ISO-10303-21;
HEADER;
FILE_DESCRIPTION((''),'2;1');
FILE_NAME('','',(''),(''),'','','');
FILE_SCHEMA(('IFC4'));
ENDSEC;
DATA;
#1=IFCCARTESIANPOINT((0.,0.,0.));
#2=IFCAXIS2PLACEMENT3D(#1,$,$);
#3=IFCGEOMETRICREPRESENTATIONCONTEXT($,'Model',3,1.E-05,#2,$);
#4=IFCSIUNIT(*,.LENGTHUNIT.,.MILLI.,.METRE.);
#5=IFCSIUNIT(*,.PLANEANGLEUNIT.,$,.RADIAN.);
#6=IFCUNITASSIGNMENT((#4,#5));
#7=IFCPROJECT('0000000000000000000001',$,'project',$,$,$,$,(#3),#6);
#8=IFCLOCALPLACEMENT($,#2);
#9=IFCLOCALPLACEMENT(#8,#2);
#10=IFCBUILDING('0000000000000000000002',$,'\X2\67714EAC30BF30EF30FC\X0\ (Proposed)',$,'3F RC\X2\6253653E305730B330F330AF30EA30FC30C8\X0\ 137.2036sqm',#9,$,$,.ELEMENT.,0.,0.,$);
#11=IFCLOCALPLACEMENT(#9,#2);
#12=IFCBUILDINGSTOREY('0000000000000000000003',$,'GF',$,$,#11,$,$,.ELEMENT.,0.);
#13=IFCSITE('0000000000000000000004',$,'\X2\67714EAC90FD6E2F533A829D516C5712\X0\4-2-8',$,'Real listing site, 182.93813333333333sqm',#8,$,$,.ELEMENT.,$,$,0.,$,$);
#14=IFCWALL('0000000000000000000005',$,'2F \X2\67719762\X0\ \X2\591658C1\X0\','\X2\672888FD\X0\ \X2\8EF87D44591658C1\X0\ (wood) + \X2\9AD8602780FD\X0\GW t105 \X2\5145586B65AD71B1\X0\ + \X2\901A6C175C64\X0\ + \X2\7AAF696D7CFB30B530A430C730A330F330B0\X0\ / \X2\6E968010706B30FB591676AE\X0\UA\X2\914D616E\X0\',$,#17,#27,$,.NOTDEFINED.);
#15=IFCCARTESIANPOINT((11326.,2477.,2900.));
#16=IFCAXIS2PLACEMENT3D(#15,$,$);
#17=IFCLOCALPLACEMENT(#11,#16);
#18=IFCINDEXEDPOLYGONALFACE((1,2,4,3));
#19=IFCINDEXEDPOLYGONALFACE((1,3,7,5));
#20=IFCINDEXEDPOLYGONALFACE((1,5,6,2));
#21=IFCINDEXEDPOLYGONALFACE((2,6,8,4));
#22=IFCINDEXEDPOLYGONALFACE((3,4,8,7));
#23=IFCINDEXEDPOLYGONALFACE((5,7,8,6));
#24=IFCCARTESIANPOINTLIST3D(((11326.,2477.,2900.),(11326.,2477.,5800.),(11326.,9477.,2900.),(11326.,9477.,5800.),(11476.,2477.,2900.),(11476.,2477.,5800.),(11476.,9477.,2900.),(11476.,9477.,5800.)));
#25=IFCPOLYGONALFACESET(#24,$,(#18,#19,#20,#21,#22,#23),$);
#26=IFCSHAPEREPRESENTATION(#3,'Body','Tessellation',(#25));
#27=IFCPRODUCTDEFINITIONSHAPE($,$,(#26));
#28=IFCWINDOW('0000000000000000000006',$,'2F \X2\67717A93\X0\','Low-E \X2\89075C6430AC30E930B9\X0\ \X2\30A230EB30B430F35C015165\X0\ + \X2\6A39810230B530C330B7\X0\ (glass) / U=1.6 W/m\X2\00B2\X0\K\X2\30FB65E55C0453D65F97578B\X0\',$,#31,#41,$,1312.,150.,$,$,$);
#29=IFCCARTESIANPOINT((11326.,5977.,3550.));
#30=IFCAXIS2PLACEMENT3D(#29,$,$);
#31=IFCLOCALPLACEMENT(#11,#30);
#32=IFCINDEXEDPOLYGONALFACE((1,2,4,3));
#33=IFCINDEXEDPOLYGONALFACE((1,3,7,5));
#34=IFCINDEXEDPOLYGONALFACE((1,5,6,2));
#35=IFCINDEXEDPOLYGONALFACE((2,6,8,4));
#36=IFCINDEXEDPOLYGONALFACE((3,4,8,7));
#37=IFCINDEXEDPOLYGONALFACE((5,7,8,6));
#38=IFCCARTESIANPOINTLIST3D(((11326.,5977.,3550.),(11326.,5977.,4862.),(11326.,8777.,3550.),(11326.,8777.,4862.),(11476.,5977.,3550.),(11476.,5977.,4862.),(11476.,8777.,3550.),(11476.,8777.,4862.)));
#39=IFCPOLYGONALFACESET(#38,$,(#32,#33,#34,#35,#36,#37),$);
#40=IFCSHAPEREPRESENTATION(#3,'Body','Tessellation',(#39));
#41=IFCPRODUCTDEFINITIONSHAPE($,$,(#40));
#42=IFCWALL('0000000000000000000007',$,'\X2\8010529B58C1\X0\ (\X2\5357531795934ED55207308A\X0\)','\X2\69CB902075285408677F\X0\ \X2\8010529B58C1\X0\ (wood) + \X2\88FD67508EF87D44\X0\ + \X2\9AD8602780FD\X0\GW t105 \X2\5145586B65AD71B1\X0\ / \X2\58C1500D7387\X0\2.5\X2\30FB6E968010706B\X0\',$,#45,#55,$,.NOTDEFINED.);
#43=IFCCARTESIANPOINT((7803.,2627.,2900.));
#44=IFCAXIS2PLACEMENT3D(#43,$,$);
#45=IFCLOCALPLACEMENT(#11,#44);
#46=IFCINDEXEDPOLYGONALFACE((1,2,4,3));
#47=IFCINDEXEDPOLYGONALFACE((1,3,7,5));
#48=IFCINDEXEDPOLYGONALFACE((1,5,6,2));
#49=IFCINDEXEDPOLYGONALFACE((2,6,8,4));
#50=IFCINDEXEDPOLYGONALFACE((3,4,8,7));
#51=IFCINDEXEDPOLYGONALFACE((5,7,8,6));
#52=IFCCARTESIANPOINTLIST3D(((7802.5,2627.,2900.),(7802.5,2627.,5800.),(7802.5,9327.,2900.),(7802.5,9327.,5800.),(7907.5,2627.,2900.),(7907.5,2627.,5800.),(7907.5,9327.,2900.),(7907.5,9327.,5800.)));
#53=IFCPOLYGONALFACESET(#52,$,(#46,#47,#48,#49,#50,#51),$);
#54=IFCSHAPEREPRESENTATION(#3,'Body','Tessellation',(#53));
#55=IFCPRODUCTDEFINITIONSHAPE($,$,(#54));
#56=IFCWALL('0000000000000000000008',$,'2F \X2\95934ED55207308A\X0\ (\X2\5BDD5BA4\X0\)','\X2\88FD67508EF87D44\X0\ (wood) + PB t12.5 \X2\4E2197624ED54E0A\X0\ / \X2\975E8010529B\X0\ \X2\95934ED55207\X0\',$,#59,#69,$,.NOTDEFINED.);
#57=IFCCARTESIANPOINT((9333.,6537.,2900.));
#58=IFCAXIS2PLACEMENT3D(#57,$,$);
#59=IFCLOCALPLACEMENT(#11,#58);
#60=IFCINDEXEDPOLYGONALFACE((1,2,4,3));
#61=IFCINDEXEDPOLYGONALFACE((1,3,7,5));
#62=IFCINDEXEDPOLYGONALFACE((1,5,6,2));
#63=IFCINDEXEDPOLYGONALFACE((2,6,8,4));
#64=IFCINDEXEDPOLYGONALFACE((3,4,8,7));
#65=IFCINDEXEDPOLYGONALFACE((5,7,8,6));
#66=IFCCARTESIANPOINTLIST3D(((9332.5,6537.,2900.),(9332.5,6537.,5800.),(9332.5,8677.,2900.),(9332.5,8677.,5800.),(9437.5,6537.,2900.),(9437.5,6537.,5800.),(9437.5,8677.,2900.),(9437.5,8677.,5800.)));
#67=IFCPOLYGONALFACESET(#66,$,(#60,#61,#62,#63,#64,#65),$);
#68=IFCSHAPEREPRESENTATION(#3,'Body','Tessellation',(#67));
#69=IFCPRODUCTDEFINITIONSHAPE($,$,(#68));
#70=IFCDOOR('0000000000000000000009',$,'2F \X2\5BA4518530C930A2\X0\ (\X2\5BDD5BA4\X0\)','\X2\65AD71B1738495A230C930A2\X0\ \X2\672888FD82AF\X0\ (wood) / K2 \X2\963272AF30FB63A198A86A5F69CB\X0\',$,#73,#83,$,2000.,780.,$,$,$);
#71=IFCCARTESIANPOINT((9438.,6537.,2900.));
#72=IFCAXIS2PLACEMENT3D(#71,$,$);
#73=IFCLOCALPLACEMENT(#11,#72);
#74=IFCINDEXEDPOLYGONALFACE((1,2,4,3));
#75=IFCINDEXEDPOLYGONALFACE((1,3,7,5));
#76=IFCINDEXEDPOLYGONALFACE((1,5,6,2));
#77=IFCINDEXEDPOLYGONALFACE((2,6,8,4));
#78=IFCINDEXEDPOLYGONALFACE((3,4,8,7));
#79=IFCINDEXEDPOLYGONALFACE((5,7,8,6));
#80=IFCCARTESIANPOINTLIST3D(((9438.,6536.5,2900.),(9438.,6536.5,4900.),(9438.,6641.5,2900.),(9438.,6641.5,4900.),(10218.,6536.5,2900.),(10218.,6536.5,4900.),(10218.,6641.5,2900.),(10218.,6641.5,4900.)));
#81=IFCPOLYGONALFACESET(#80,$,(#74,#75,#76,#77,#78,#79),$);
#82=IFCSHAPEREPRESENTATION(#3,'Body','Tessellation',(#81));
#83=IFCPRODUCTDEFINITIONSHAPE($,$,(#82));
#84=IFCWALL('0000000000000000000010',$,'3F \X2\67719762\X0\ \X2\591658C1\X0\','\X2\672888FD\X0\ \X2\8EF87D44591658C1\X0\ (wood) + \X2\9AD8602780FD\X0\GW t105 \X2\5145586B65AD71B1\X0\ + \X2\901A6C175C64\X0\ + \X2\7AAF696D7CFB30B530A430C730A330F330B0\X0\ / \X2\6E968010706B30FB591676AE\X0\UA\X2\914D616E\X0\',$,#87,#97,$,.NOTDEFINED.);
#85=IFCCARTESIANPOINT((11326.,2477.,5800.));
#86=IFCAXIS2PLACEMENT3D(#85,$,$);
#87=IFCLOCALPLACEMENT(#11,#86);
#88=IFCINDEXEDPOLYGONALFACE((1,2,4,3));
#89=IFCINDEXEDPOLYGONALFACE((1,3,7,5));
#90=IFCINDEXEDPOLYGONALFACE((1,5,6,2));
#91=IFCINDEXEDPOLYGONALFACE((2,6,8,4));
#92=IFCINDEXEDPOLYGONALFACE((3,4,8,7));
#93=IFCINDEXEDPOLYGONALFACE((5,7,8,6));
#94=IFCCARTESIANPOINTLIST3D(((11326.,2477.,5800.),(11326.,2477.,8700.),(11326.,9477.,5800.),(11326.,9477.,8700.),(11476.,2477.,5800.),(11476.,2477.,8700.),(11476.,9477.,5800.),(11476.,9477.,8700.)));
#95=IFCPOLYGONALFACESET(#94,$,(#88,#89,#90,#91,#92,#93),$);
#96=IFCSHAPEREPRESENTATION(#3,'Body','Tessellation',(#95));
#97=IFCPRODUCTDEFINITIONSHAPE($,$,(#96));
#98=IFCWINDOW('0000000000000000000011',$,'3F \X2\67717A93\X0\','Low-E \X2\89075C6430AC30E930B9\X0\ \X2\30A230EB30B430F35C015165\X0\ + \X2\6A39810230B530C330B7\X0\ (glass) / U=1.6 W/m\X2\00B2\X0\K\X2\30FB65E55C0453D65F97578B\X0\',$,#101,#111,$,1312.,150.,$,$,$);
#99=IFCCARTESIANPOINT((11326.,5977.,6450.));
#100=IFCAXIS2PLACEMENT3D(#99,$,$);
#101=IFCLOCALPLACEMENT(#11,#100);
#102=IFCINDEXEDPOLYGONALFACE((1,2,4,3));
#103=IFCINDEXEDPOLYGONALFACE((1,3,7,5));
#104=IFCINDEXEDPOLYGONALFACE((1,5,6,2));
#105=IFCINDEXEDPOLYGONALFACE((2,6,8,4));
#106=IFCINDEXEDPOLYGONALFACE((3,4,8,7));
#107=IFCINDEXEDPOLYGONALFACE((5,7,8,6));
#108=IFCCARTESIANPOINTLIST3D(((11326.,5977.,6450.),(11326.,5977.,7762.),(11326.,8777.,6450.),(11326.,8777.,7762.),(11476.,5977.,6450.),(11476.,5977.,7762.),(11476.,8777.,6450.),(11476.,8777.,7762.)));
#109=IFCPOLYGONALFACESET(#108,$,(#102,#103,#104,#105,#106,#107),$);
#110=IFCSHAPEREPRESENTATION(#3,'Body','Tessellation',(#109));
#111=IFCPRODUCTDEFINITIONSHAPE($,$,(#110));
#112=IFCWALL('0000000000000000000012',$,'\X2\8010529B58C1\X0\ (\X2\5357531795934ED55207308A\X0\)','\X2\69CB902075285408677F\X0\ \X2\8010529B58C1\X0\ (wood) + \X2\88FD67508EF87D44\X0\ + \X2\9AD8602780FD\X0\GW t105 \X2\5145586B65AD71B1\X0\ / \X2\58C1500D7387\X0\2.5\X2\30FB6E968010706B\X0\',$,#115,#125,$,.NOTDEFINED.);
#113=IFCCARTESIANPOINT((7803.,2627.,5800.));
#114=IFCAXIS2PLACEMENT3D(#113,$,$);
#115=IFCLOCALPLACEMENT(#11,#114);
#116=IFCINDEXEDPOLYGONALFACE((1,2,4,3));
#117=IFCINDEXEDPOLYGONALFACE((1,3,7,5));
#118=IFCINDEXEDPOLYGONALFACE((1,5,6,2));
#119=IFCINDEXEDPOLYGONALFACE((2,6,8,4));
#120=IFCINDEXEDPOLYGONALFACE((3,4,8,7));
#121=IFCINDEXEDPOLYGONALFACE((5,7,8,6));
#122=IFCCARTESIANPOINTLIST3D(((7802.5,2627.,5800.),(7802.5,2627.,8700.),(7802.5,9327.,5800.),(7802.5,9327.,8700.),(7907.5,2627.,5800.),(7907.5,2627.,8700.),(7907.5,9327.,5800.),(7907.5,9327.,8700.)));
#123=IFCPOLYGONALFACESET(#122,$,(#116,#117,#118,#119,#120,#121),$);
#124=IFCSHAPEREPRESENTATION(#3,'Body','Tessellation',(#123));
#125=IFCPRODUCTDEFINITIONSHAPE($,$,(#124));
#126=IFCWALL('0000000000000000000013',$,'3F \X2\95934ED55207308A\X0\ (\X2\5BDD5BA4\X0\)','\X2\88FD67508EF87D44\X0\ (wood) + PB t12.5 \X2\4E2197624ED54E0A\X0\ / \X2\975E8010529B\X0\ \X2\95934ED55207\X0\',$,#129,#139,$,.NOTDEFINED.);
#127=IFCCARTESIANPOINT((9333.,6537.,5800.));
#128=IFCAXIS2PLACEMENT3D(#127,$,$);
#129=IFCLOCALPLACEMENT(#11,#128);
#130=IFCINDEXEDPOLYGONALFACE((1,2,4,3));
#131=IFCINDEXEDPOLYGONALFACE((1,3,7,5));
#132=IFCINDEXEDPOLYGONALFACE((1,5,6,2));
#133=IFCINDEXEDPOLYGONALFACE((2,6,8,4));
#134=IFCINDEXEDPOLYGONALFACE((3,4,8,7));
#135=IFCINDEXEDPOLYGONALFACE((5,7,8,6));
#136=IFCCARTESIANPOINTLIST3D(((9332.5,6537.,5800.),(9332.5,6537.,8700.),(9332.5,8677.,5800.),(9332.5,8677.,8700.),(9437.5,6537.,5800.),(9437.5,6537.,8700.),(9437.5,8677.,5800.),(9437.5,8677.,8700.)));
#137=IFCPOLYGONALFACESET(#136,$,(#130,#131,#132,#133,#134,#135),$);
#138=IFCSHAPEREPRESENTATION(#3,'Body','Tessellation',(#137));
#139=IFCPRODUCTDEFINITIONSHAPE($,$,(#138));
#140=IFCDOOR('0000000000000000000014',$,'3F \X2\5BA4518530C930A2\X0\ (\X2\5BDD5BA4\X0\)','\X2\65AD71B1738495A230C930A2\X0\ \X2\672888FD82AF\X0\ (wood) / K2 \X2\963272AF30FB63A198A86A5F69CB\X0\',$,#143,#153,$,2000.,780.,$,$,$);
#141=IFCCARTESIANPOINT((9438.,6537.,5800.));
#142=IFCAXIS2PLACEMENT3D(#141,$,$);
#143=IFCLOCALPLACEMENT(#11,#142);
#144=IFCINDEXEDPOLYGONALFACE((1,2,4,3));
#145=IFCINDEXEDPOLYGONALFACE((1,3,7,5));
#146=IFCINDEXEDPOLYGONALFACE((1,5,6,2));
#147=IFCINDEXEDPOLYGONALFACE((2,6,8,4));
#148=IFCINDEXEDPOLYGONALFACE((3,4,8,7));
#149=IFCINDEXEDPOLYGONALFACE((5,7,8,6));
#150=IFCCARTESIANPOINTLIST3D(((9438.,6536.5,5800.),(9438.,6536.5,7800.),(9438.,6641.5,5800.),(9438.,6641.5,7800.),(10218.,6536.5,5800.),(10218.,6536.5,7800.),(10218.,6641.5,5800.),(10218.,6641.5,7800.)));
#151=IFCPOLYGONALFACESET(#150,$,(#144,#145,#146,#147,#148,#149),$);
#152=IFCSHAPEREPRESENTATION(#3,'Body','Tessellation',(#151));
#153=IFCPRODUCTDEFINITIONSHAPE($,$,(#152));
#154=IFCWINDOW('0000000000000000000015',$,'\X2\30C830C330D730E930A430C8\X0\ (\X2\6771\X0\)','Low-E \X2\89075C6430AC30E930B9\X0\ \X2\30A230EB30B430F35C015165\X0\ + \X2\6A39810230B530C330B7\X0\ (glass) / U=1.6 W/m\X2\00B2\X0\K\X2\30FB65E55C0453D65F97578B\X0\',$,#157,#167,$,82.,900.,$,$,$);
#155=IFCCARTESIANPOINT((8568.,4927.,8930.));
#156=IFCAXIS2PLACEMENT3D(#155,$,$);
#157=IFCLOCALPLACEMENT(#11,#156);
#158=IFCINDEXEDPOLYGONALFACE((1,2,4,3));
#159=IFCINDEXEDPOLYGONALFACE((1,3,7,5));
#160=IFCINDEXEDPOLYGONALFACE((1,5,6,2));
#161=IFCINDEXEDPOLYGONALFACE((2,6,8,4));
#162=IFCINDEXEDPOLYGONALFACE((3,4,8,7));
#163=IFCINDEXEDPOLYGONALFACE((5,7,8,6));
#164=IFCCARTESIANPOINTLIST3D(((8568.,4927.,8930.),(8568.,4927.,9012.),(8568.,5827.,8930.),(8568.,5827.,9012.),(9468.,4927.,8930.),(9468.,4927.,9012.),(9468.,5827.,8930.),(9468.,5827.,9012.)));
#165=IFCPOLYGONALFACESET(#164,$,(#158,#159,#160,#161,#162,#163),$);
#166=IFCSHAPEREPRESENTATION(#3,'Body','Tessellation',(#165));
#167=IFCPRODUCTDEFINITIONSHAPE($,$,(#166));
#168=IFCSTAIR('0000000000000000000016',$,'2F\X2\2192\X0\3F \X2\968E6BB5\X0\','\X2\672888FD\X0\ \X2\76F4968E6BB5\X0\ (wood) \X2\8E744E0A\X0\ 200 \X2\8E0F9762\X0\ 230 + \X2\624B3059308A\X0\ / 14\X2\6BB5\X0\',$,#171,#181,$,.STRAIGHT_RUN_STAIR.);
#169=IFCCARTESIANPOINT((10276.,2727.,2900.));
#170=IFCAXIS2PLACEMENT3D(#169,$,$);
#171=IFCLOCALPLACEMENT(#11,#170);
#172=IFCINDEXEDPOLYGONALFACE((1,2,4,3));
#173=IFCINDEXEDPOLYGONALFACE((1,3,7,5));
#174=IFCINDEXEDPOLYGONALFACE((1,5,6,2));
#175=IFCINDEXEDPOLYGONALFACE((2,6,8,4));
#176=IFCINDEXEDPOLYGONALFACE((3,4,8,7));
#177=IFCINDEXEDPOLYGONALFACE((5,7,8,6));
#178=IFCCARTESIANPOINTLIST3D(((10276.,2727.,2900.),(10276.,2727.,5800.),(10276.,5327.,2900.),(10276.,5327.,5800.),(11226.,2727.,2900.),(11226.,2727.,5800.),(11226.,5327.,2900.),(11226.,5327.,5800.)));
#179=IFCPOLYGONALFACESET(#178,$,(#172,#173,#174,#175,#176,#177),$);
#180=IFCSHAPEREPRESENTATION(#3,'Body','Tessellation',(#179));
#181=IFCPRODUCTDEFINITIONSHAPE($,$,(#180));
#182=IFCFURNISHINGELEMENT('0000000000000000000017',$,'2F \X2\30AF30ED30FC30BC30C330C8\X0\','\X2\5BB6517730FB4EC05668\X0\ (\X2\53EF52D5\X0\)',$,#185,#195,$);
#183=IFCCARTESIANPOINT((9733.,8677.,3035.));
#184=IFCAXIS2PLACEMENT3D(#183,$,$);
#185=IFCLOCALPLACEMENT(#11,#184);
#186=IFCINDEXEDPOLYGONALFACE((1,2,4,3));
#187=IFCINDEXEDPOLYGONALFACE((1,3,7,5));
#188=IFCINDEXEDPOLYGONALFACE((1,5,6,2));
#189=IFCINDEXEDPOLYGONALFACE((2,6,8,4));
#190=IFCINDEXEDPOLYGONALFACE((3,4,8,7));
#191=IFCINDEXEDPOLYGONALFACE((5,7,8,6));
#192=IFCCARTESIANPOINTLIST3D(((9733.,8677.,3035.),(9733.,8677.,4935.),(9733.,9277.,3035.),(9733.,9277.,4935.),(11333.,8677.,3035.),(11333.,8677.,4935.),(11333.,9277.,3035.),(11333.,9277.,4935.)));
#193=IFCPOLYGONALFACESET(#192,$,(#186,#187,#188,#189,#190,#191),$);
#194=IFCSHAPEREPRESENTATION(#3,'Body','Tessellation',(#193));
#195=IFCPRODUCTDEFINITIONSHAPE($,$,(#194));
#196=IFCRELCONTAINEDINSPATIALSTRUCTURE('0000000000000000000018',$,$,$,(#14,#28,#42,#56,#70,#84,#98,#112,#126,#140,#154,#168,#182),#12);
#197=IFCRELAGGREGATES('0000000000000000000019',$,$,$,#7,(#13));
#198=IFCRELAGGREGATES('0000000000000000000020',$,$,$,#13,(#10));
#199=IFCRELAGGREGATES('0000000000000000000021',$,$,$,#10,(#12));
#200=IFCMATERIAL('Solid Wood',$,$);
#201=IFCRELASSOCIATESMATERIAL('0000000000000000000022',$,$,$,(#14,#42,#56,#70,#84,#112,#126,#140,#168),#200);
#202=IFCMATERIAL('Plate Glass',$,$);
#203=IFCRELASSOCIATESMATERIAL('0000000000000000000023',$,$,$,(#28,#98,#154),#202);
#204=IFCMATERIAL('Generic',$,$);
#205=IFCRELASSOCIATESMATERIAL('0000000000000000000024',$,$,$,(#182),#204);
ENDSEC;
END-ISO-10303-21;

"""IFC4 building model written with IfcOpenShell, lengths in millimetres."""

from ifc_helpers import new_model, si_unit, frame, frame_2d, origin, place, context, project, spatial, rectangle, extrude, material, element, fill, save


model = new_model("IFC4")

# Units and contexts
model_context = context("Model", 3, precision=1e-05, world=origin())
ifc_project = project(units=[si_unit("LENGTHUNIT", "METRE", prefix="MILLI"), si_unit("PLANEANGLEUNIT", "RADIAN")], contexts=[model_context])

# Site, building, storey
site_placement = place(None, origin())
site = spatial("IfcSite", under=ifc_project, at=site_placement, Name="東京都港区芝公園4-2-8", ObjectType="Real listing site, 182.93813333333333sqm", CompositionType="ELEMENT", RefElevation=0.0)
building_placement = place(site_placement, origin())
building = spatial("IfcBuilding", under=site, at=building_placement, Name="東京タワー (Proposed)", ObjectType="3F RC打放しコンクリート 137.2036sqm", CompositionType="ELEMENT", ElevationOfRefHeight=0.0, ElevationOfTerrain=0.0)
storey_placement = place(building_placement, origin())
storey = spatial("IfcBuildingStorey", under=building, at=storey_placement, Name="GF", CompositionType="ELEMENT", Elevation=0.0)

# Wall, opening, window
ifc_material_1 = material(Name="Solid Wood")
wall_1_placement = place(storey_placement, frame((11326.0, 2477.0, 2900.0)))
wall_1 = element("IfcWall", 1, at=wall_1_placement, inside=storey, material=ifc_material_1, Name="2F 東面 外壁", Description="木製 軸組外壁 (wood) + 高性能GW t105 充填断熱 + 通気層 + 窯業系サイディング / 準耐火・外皮UA配慮", PredefinedType="NOTDEFINED", context=model_context, shape_type="SweptSolid", body=[
    extrude(rectangle(XDim=150.0, YDim=7000.0, at=frame_2d((75.0, 3500.0))), frame((11326.0, 2477.0, 2900.0)), (0.0, 0.0, 1.0), 2900.0),
])
opening_1_placement = place(storey_placement, frame((11326.0, 5977.0, 3550.0)))
opening_1 = element("IfcOpeningElement", 2, at=opening_1_placement, cuts=wall_1, PredefinedType="NOTDEFINED", context=model_context, shape_type="SweptSolid", body=[
    extrude(rectangle(XDim=150.0, YDim=2800.0, at=frame_2d((75.0, 1400.0))), frame((11326.0, 5977.0, 3550.0)), (0.0, 0.0, 1.0), 1312.0),
])
ifc_material_2 = material(Name="Plate Glass")
window_1_placement = place(storey_placement, frame((11326.0, 5977.0, 3550.0)))
window_1 = element("IfcWindow", 3, at=window_1_placement, inside=storey, material=ifc_material_2, Name="2F 東窓", Description="Low-E 複層ガラス アルゴン封入 + 樹脂サッシ (glass) / U=1.6 W/m²K・日射取得型", OverallHeight=1312.0, OverallWidth=150.0, context=model_context, shape_type="SweptSolid", body=[
    extrude(rectangle(XDim=150.0, YDim=2800.0, at=frame_2d((75.0, 1400.0))), frame((11326.0, 5977.0, 3550.0)), (0.0, 0.0, 1.0), 1312.0),
])
fill(opening_1, window_1)

# Walls
wall_2_placement = place(storey_placement, frame((7803.0, 2627.0, 2900.0)))
element("IfcWall", 4, at=wall_2_placement, inside=storey, material=ifc_material_1, Name="耐力壁 (南北間仕切り)", Description="構造用合板 耐力壁 (wood) + 製材軸組 + 高性能GW t105 充填断熱 / 壁倍率2.5・準耐火", PredefinedType="NOTDEFINED", context=model_context, shape_type="SweptSolid", body=[
    extrude(rectangle(XDim=105.0, YDim=6700.0, at=frame_2d((52.0, 3350.0))), frame((7803.0, 2627.0, 2900.0)), (0.0, 0.0, 1.0), 2900.0),
])
wall_3_placement = place(storey_placement, frame((9333.0, 6537.0, 2900.0)))
element("IfcWall", 5, at=wall_3_placement, inside=storey, material=ifc_material_1, Name="2F 間仕切り (寝室)", Description="製材軸組 (wood) + PB t12.5 両面仕上 / 非耐力 間仕切", PredefinedType="NOTDEFINED", context=model_context, shape_type="SweptSolid", body=[
    extrude(rectangle(XDim=105.0, YDim=2140.0, at=frame_2d((52.0, 1070.0))), frame((9333.0, 6537.0, 2900.0)), (0.0, 0.0, 1.0), 2900.0),
])

# Door
door_1_placement = place(storey_placement, frame((9438.0, 6537.0, 2900.0)))
element("IfcDoor", 6, at=door_1_placement, inside=storey, material=ifc_material_1, Name="2F 室内ドア (寝室)", Description="断熱玄関ドア 木製芯 (wood) / K2 防犯・採風機構", OverallHeight=2000.0, OverallWidth=780.0, context=model_context, shape_type="SweptSolid", body=[
    extrude(rectangle(XDim=780.0, YDim=105.0, at=frame_2d((390.0, 52.0))), frame((9438.0, 6537.0, 2900.0)), (0.0, 0.0, 1.0), 2000.0),
])

# Wall, opening, window
wall_4_placement = place(storey_placement, frame((11326.0, 2477.0, 5800.0)))
wall_4 = element("IfcWall", 7, at=wall_4_placement, inside=storey, material=ifc_material_1, Name="3F 東面 外壁", Description="木製 軸組外壁 (wood) + 高性能GW t105 充填断熱 + 通気層 + 窯業系サイディング / 準耐火・外皮UA配慮", PredefinedType="NOTDEFINED", context=model_context, shape_type="SweptSolid", body=[
    extrude(rectangle(XDim=150.0, YDim=7000.0, at=frame_2d((75.0, 3500.0))), frame((11326.0, 2477.0, 5800.0)), (0.0, 0.0, 1.0), 2900.0),
])
opening_2_placement = place(storey_placement, frame((11326.0, 5977.0, 6450.0)))
opening_2 = element("IfcOpeningElement", 8, at=opening_2_placement, cuts=wall_4, PredefinedType="NOTDEFINED", context=model_context, shape_type="SweptSolid", body=[
    extrude(rectangle(XDim=150.0, YDim=2800.0, at=frame_2d((75.0, 1400.0))), frame((11326.0, 5977.0, 6450.0)), (0.0, 0.0, 1.0), 1312.0),
])
window_2_placement = place(storey_placement, frame((11326.0, 5977.0, 6450.0)))
window_2 = element("IfcWindow", 9, at=window_2_placement, inside=storey, material=ifc_material_2, Name="3F 東窓", Description="Low-E 複層ガラス アルゴン封入 + 樹脂サッシ (glass) / U=1.6 W/m²K・日射取得型", OverallHeight=1312.0, OverallWidth=150.0, context=model_context, shape_type="SweptSolid", body=[
    extrude(rectangle(XDim=150.0, YDim=2800.0, at=frame_2d((75.0, 1400.0))), frame((11326.0, 5977.0, 6450.0)), (0.0, 0.0, 1.0), 1312.0),
])
fill(opening_2, window_2)

# Walls
wall_5_placement = place(storey_placement, frame((7803.0, 2627.0, 5800.0)))
element("IfcWall", 10, at=wall_5_placement, inside=storey, material=ifc_material_1, Name="耐力壁 (南北間仕切り)", Description="構造用合板 耐力壁 (wood) + 製材軸組 + 高性能GW t105 充填断熱 / 壁倍率2.5・準耐火", PredefinedType="NOTDEFINED", context=model_context, shape_type="SweptSolid", body=[
    extrude(rectangle(XDim=105.0, YDim=6700.0, at=frame_2d((52.0, 3350.0))), frame((7803.0, 2627.0, 5800.0)), (0.0, 0.0, 1.0), 2900.0),
])
wall_6_placement = place(storey_placement, frame((9333.0, 6537.0, 5800.0)))
element("IfcWall", 11, at=wall_6_placement, inside=storey, material=ifc_material_1, Name="3F 間仕切り (寝室)", Description="製材軸組 (wood) + PB t12.5 両面仕上 / 非耐力 間仕切", PredefinedType="NOTDEFINED", context=model_context, shape_type="SweptSolid", body=[
    extrude(rectangle(XDim=105.0, YDim=2140.0, at=frame_2d((52.0, 1070.0))), frame((9333.0, 6537.0, 5800.0)), (0.0, 0.0, 1.0), 2900.0),
])

# Door
door_2_placement = place(storey_placement, frame((9438.0, 6537.0, 5800.0)))
element("IfcDoor", 12, at=door_2_placement, inside=storey, material=ifc_material_1, Name="3F 室内ドア (寝室)", Description="断熱玄関ドア 木製芯 (wood) / K2 防犯・採風機構", OverallHeight=2000.0, OverallWidth=780.0, context=model_context, shape_type="SweptSolid", body=[
    extrude(rectangle(XDim=780.0, YDim=105.0, at=frame_2d((390.0, 52.0))), frame((9438.0, 6537.0, 5800.0)), (0.0, 0.0, 1.0), 2000.0),
])

# Window
window_3_placement = place(storey_placement, frame((8568.0, 4927.0, 8930.0)))
element("IfcWindow", 13, at=window_3_placement, inside=storey, material=ifc_material_2, Name="トップライト (東)", Description="Low-E 複層ガラス アルゴン封入 + 樹脂サッシ (glass) / U=1.6 W/m²K・日射取得型", OverallHeight=82.0, OverallWidth=900.0, context=model_context, shape_type="SweptSolid", body=[
    extrude(rectangle(XDim=900.0, YDim=900.0, at=frame_2d((450.0, 450.0))), frame((8568.0, 4927.0, 8930.0)), (0.0, 0.0, 1.0), 82.0),
])

# Stair
stair_placement = place(storey_placement, frame((10276.0, 2727.0, 2900.0)))
element("IfcStair", 14, at=stair_placement, inside=storey, material=ifc_material_1, Name="2F→3F 階段", Description="木製 直階段 (wood) 蹴上 200 踏面 230 + 手すり / 14段", PredefinedType="STRAIGHT_RUN_STAIR", context=model_context, shape_type="SweptSolid", body=[
    extrude(rectangle(XDim=950.0, YDim=2600.0, at=frame_2d((475.0, 1300.0))), frame((10276.0, 2727.0, 2900.0)), (0.0, 0.0, 1.0), 2900.0),
])

# Furnishing element
ifc_material_3 = material(Name="Generic")
furnishing_1_placement = place(storey_placement, frame((9733.0, 8677.0, 3035.0)))
element("IfcFurnishingElement", 15, at=furnishing_1_placement, inside=storey, material=ifc_material_3, Name="2F クローゼット", Description="家具・什器 (可動)", context=model_context, shape_type="SweptSolid", body=[
    extrude(rectangle(XDim=1600.0, YDim=600.0, at=frame_2d((800.0, 300.0))), frame((9733.0, 8677.0, 3035.0)), (0.0, 0.0, 1.0), 1900.0),
])

save(model, "model.ifc")
